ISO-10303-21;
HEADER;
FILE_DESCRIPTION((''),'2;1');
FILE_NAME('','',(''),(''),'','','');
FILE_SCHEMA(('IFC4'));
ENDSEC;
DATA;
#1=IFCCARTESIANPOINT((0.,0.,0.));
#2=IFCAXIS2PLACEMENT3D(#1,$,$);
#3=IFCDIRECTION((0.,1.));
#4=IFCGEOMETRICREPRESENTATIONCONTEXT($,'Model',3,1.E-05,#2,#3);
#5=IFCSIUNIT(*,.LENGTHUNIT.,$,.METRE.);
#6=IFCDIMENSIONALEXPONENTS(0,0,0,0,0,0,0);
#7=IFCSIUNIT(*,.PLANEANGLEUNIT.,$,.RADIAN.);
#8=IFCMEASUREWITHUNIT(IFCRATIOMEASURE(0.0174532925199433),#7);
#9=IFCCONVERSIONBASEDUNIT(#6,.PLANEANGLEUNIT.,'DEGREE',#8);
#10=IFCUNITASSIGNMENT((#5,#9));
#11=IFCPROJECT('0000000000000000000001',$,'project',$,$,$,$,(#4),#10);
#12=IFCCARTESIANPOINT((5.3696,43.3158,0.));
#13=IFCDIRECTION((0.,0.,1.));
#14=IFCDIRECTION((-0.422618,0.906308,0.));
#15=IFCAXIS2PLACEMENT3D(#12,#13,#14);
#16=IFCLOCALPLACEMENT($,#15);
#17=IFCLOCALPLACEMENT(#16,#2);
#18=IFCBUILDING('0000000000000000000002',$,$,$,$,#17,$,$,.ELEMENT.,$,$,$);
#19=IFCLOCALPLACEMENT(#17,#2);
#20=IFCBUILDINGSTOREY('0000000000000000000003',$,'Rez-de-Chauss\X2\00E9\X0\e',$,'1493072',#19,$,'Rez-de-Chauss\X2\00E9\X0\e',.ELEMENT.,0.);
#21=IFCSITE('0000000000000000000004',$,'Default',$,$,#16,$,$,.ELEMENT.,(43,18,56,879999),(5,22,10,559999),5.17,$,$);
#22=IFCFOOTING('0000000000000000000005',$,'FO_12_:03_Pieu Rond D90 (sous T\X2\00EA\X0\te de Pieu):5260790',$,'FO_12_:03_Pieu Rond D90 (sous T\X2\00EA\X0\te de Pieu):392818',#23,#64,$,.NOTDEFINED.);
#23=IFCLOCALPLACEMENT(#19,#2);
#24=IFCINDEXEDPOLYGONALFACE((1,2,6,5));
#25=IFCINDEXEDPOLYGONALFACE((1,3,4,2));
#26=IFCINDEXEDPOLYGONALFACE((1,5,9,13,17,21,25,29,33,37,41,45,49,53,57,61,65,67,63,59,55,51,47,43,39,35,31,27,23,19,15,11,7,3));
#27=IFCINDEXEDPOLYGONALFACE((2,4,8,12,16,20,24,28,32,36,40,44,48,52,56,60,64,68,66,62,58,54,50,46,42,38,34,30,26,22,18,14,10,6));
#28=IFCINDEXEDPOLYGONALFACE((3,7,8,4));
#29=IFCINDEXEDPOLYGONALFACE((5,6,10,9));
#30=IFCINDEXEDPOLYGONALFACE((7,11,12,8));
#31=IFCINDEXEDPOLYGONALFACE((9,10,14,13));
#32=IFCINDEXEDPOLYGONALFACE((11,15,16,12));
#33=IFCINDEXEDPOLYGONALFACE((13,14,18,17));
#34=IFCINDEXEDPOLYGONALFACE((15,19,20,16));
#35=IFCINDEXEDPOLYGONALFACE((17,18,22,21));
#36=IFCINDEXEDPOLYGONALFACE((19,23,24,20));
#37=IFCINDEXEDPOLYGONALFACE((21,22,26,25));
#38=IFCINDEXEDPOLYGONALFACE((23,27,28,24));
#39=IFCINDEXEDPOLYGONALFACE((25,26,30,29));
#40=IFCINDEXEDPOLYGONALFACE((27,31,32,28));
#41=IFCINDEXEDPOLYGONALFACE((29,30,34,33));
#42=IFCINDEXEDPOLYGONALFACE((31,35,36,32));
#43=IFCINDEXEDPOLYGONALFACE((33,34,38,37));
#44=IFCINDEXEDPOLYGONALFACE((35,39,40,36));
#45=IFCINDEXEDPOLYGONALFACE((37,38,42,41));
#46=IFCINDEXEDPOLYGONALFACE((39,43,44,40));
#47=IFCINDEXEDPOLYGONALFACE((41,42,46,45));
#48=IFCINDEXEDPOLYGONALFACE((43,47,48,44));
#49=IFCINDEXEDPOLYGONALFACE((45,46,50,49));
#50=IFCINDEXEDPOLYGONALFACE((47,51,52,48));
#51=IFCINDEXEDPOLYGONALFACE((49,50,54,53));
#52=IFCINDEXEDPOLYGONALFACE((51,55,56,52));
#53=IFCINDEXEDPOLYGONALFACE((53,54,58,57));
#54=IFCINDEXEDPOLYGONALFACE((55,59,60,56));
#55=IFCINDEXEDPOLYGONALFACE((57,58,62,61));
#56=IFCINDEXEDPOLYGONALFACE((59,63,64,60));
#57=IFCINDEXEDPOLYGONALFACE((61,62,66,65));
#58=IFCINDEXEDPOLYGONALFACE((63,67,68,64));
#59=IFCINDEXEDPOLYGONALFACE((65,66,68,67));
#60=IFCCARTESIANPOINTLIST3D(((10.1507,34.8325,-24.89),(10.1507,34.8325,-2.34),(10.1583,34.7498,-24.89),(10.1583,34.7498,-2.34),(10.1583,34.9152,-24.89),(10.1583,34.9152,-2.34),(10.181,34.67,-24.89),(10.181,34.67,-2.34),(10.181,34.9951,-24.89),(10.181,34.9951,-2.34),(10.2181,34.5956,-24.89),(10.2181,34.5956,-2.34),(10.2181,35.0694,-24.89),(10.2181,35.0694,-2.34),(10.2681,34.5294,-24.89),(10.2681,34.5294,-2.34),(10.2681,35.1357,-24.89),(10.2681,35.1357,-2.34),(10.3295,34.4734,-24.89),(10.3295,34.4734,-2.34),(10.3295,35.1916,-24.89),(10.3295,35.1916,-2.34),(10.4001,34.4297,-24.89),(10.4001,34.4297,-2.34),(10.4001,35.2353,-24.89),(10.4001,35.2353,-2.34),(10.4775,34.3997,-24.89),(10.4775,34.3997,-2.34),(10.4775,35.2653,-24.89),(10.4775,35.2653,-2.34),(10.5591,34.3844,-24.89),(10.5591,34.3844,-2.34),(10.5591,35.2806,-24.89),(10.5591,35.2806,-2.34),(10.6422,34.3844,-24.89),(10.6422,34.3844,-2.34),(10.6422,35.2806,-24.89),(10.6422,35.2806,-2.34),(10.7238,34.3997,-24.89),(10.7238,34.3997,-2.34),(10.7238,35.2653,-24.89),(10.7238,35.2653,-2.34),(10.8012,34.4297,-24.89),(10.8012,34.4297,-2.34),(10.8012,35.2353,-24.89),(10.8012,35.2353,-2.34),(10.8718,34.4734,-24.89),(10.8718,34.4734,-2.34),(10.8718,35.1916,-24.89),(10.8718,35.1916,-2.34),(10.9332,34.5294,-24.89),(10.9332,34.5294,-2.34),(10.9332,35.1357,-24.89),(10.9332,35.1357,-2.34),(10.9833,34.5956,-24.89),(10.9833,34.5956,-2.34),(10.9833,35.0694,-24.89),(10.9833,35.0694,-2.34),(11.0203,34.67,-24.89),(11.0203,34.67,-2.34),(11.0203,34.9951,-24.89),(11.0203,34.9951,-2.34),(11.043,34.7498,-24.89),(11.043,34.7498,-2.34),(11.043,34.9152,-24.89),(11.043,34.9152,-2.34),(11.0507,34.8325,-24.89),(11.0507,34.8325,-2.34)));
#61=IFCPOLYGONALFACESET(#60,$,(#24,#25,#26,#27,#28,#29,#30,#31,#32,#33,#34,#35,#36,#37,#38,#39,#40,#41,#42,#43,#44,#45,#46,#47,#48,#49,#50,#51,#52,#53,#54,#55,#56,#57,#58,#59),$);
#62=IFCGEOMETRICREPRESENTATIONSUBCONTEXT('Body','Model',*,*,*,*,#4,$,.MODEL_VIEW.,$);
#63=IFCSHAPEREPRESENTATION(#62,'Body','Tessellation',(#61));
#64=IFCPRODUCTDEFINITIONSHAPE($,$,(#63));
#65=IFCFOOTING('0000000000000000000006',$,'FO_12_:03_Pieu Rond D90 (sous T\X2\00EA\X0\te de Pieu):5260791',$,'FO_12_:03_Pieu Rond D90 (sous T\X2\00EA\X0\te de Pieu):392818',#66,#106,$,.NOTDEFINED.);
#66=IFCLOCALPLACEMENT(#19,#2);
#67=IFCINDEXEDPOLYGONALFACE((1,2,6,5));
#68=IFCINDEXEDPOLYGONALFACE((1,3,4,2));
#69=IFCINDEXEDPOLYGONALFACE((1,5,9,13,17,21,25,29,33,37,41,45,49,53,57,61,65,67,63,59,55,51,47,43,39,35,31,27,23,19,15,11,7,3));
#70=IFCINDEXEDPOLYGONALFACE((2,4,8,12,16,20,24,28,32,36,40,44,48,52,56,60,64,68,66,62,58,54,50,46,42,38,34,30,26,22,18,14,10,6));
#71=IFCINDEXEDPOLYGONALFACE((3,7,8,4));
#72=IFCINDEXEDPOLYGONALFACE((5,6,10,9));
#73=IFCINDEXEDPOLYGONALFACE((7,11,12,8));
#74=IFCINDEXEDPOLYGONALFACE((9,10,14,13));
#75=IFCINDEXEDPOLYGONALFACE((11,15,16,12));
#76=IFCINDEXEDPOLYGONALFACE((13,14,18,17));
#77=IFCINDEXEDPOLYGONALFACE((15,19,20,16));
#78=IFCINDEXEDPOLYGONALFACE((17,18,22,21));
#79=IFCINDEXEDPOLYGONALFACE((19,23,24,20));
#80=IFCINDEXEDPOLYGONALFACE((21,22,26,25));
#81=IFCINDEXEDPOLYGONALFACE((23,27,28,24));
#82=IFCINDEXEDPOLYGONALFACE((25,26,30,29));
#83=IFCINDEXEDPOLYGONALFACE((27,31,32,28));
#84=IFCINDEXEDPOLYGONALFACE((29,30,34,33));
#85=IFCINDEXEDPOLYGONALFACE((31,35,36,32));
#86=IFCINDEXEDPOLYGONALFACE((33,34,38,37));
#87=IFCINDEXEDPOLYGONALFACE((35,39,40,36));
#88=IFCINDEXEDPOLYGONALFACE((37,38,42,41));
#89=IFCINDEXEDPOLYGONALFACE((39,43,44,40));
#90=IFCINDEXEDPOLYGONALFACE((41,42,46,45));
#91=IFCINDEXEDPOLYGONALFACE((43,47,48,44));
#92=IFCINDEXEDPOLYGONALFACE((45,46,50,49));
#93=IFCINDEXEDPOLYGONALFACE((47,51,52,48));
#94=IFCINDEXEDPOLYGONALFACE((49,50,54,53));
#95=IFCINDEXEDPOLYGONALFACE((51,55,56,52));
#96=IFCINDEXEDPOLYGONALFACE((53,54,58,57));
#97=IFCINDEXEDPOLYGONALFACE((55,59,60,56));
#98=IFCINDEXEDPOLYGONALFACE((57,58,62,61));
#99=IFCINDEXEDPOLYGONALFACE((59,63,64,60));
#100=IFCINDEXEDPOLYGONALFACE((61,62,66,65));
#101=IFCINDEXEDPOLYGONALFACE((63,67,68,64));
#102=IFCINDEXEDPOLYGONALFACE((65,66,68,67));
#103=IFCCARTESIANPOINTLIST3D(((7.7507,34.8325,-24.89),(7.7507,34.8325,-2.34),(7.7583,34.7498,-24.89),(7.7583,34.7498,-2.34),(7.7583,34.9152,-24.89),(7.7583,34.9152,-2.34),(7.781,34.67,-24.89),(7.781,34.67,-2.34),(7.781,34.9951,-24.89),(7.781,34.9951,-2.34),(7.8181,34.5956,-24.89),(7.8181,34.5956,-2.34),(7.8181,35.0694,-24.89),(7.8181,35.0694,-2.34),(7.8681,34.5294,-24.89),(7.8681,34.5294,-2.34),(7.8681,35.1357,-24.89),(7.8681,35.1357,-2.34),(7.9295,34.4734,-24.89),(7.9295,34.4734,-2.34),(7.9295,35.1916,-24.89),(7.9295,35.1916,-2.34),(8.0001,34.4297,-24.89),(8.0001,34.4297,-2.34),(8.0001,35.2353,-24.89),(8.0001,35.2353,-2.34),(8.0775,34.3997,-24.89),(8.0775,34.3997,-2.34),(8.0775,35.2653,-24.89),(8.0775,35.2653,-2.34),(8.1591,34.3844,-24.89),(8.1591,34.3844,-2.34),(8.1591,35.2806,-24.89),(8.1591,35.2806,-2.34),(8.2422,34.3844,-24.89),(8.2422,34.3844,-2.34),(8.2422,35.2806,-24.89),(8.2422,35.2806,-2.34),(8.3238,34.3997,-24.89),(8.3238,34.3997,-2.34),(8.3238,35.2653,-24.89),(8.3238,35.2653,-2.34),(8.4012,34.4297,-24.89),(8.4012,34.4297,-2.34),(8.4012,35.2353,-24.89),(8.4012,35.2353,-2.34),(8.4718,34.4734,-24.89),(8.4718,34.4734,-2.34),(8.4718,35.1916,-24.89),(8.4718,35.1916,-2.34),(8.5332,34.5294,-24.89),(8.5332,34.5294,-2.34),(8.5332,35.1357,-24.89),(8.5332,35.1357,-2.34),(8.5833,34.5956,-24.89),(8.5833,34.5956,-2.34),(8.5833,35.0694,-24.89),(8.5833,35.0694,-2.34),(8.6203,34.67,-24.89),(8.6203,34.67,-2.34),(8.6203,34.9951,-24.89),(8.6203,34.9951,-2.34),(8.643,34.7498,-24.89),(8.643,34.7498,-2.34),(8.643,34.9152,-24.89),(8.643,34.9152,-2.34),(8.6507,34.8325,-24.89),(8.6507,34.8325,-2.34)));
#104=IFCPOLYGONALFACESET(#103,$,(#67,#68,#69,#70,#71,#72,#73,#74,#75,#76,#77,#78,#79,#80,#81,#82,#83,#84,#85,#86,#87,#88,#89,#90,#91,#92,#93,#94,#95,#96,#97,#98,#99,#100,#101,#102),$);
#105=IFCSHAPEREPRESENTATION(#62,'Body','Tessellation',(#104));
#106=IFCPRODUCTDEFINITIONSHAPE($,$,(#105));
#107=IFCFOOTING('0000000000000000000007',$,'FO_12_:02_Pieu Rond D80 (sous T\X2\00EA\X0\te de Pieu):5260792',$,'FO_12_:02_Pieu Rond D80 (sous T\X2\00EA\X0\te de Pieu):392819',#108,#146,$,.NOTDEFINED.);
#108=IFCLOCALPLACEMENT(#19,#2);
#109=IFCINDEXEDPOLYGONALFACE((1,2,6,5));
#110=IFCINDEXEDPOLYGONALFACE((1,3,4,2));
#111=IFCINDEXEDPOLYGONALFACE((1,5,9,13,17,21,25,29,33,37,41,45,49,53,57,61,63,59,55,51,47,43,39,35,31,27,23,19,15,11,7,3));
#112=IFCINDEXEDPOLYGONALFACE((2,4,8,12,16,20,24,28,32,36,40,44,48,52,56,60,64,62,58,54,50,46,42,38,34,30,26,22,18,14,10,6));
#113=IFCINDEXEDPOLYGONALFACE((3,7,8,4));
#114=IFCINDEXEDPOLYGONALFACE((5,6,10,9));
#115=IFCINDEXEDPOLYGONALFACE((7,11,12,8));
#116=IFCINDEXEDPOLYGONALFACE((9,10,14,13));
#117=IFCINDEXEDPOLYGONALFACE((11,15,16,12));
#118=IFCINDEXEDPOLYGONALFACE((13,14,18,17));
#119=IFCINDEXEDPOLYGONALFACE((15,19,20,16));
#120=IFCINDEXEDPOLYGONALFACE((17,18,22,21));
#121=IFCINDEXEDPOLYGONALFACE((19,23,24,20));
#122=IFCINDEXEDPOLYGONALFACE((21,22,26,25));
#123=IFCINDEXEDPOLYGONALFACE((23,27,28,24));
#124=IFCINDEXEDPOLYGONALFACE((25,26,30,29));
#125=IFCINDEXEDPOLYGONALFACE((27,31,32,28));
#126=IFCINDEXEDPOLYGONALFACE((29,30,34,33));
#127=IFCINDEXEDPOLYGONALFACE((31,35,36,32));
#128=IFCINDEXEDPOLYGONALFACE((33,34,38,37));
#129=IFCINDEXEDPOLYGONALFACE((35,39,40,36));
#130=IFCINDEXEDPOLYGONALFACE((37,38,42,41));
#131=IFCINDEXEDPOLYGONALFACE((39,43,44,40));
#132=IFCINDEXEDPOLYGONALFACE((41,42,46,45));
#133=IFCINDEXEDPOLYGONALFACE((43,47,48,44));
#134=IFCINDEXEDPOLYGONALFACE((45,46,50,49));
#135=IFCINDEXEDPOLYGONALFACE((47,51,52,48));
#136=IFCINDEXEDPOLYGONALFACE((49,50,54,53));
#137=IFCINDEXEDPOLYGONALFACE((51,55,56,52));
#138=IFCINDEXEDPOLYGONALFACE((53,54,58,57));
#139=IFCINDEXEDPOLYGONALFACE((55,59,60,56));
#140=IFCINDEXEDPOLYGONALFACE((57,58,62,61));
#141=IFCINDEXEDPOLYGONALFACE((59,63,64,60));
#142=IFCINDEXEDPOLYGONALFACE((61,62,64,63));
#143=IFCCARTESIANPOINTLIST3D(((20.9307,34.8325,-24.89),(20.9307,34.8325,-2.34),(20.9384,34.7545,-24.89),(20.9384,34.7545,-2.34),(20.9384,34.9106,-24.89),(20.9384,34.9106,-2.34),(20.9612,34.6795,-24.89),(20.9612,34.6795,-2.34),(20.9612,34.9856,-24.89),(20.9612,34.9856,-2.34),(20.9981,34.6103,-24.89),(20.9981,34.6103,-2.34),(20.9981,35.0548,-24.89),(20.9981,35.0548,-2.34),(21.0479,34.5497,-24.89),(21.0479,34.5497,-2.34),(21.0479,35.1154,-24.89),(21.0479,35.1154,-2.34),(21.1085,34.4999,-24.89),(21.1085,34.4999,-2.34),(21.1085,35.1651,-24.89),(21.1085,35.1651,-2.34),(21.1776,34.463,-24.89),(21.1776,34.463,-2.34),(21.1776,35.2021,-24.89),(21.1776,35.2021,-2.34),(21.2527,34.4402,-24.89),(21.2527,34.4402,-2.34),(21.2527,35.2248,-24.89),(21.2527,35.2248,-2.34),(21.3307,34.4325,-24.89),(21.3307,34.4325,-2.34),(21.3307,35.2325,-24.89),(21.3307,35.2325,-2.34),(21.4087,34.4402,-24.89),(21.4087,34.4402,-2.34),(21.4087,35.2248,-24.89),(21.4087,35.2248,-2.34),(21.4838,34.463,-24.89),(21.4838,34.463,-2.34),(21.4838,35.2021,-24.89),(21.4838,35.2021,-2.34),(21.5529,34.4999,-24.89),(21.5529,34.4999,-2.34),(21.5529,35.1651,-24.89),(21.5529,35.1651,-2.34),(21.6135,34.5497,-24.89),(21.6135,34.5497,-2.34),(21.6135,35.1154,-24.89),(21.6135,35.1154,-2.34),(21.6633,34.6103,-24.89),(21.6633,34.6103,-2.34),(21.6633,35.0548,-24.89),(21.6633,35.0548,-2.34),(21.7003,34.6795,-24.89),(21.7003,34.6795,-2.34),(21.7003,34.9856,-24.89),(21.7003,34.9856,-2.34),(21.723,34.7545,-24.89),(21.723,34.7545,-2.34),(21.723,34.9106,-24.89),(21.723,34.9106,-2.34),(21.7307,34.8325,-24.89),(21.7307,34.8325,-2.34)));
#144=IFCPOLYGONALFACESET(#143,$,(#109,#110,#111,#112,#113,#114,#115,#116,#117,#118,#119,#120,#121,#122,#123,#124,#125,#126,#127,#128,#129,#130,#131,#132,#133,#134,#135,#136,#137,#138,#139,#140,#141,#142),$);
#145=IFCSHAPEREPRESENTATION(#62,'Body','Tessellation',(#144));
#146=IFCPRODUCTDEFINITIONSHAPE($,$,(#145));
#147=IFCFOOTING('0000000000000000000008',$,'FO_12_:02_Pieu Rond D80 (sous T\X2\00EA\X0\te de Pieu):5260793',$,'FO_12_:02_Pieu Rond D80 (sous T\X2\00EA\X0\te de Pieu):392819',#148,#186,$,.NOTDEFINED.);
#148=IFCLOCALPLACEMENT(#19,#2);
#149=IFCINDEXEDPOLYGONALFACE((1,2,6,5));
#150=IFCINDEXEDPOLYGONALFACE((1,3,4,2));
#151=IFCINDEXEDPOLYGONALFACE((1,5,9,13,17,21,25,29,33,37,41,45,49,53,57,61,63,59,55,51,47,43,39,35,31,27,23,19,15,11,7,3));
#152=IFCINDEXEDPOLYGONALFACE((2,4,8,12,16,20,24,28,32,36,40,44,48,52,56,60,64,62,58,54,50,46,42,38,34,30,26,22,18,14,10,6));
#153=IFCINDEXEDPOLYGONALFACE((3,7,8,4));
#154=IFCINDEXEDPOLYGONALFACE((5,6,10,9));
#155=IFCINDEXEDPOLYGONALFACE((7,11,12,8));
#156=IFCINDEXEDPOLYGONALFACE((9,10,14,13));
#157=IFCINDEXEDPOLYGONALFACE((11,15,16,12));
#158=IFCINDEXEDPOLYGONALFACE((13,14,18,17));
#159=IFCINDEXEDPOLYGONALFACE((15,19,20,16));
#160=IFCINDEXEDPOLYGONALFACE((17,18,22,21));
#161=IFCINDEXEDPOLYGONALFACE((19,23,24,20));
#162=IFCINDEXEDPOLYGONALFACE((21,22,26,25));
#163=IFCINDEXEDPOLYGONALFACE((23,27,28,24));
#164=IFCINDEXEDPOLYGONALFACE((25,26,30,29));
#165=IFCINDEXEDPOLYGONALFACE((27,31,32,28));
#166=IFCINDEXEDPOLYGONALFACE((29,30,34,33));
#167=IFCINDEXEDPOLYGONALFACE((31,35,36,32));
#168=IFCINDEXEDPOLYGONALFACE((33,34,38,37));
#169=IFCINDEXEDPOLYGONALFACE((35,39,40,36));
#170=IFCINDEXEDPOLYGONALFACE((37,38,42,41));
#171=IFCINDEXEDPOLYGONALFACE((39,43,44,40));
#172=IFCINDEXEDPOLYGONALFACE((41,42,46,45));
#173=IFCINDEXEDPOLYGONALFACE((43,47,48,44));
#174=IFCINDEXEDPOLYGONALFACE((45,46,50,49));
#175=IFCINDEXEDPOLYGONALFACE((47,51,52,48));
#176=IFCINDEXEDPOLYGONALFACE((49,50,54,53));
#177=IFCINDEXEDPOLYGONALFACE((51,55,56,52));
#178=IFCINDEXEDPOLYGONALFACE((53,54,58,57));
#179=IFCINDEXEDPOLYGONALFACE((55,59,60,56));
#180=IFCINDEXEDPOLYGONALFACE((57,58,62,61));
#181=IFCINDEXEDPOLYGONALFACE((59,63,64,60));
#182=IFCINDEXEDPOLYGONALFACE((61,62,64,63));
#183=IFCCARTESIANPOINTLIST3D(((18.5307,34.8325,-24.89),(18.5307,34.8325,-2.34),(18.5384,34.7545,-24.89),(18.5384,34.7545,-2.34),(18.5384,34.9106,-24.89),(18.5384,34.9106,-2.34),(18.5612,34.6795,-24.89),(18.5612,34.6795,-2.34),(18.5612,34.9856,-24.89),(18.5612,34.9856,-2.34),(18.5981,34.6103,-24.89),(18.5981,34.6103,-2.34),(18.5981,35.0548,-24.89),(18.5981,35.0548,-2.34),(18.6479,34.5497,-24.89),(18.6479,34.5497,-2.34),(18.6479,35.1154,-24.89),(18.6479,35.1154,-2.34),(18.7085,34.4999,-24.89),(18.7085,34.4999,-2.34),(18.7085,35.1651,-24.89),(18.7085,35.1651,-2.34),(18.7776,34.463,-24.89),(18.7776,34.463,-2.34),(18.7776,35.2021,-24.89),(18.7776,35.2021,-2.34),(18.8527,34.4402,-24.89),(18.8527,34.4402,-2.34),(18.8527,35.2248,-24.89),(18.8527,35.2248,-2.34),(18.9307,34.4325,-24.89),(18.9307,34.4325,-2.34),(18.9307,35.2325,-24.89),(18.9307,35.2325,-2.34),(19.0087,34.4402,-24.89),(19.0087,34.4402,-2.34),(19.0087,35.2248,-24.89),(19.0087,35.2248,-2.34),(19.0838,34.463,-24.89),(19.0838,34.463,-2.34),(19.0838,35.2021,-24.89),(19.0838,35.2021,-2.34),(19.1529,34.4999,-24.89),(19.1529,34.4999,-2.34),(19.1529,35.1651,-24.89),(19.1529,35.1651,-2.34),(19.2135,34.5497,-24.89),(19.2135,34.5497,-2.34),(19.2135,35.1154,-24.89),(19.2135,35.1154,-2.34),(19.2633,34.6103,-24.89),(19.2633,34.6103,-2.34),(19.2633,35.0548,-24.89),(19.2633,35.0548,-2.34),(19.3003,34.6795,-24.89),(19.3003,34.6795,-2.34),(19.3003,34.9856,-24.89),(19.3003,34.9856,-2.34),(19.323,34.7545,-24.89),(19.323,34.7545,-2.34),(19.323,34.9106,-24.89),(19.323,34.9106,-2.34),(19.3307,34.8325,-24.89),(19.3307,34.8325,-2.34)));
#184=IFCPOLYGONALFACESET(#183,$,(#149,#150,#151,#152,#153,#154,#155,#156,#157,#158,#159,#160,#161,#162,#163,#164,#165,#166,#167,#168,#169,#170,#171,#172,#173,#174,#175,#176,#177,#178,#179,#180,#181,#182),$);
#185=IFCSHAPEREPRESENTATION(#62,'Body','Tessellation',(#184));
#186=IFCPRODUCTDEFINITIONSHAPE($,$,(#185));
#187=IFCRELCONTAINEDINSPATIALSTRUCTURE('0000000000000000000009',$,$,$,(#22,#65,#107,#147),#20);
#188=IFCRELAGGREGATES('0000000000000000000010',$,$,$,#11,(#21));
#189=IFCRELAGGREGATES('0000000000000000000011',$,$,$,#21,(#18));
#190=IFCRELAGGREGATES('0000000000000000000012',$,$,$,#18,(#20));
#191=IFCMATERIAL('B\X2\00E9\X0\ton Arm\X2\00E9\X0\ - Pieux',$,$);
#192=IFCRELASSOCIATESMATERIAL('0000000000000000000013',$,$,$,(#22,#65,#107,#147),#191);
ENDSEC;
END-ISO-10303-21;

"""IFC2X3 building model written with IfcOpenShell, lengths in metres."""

from ifc_helpers import new_model, entity, si_unit, converted_unit, direction, frame, origin, origin_2d_with_axis, place, context, subcontext, project, spatial, circle, extrude, material, element, save


model = new_model("IFC2X3")

# Units and contexts
model_context = context("Model", 3, precision=1e-05, world=origin(), true_north=direction((0.0, 1.0)))
body_context = subcontext(model_context, "Body", "Model", "MODEL_VIEW")
ifc_project = project(units=[si_unit("LENGTHUNIT", "METRE"), converted_unit("PLANEANGLEUNIT", "DEGREE", entity("IfcRatioMeasure", 0.0174532925199433), si_unit("PLANEANGLEUNIT", "RADIAN"), dimensions=[0, 0, 0, 0, 0, 0, 0])], contexts=[model_context])

# Site, building, storey
site_placement = place(None, frame((5.3696, 43.3158, 0.0), z_axis=(0.0, 0.0, 1.0), x_axis=(-0.422618, 0.906308, 0.0)))
site = spatial("IfcSite", under=ifc_project, at=site_placement, Name="Default", CompositionType="ELEMENT", RefLatitude=(43, 18, 56, 879999), RefLongitude=(5, 22, 10, 559999), RefElevation=5.17)
building_placement = place(site_placement, origin())
building = spatial("IfcBuilding", under=site, at=building_placement, CompositionType="ELEMENT")
storey_placement = place(building_placement, origin())
storey = spatial("IfcBuildingStorey", under=building, at=storey_placement, Name="Rez-de-Chaussée", ObjectType="1493072", LongName="Rez-de-Chaussée", CompositionType="ELEMENT", Elevation=0.0)

# Footings
ifc_material_1 = material(Name="Béton Armé - Pieux")
footing_1_placement = place(storey_placement, origin())
element("IfcFooting", 1, at=footing_1_placement, inside=storey, material=ifc_material_1, Name="FO_12_:03_Pieu Rond D90 (sous Tête de Pieu):5260790", ObjectType="FO_12_:03_Pieu Rond D90 (sous Tête de Pieu):392818", PredefinedType="NOTDEFINED", context=body_context, shape_type="SweptSolid", body=[
    extrude(circle(Radius=0.45, at=origin_2d_with_axis()), frame((10.6007, 34.8325, -24.89), z_axis=(0.0, 0.0, 1.0), x_axis=(-1.0, 0.0, 0.0)), (0.0, 0.0, 1.0), 22.55),
])
footing_2_placement = place(storey_placement, origin())
element("IfcFooting", 2, at=footing_2_placement, inside=storey, material=ifc_material_1, Name="FO_12_:03_Pieu Rond D90 (sous Tête de Pieu):5260791", ObjectType="FO_12_:03_Pieu Rond D90 (sous Tête de Pieu):392818", PredefinedType="NOTDEFINED", context=body_context, shape_type="SweptSolid", body=[
    extrude(circle(Radius=0.45, at=origin_2d_with_axis()), frame((8.2007, 34.8325, -24.89), z_axis=(0.0, 0.0, 1.0), x_axis=(-1.0, 0.0, 0.0)), (0.0, 0.0, 1.0), 22.55),
])
footing_3_placement = place(storey_placement, origin())
element("IfcFooting", 3, at=footing_3_placement, inside=storey, material=ifc_material_1, Name="FO_12_:02_Pieu Rond D80 (sous Tête de Pieu):5260792", ObjectType="FO_12_:02_Pieu Rond D80 (sous Tête de Pieu):392819", PredefinedType="NOTDEFINED", context=body_context, shape_type="SweptSolid", body=[
    extrude(circle(Radius=0.4, at=origin_2d_with_axis()), frame((21.3307, 34.8325, -24.89), z_axis=(0.0, 0.0, 1.0), x_axis=(-1.0, 0.0, 0.0)), (0.0, 0.0, 1.0), 22.55),
])
footing_4_placement = place(storey_placement, origin())
element("IfcFooting", 4, at=footing_4_placement, inside=storey, material=ifc_material_1, Name="FO_12_:02_Pieu Rond D80 (sous Tête de Pieu):5260793", ObjectType="FO_12_:02_Pieu Rond D80 (sous Tête de Pieu):392819", PredefinedType="NOTDEFINED", context=body_context, shape_type="SweptSolid", body=[
    extrude(circle(Radius=0.4, at=origin_2d_with_axis()), frame((18.9307, 34.8325, -24.89), z_axis=(0.0, 0.0, 1.0), x_axis=(-1.0, 0.0, 0.0)), (0.0, 0.0, 1.0), 22.55),
])

save(model, "model.ifc")
